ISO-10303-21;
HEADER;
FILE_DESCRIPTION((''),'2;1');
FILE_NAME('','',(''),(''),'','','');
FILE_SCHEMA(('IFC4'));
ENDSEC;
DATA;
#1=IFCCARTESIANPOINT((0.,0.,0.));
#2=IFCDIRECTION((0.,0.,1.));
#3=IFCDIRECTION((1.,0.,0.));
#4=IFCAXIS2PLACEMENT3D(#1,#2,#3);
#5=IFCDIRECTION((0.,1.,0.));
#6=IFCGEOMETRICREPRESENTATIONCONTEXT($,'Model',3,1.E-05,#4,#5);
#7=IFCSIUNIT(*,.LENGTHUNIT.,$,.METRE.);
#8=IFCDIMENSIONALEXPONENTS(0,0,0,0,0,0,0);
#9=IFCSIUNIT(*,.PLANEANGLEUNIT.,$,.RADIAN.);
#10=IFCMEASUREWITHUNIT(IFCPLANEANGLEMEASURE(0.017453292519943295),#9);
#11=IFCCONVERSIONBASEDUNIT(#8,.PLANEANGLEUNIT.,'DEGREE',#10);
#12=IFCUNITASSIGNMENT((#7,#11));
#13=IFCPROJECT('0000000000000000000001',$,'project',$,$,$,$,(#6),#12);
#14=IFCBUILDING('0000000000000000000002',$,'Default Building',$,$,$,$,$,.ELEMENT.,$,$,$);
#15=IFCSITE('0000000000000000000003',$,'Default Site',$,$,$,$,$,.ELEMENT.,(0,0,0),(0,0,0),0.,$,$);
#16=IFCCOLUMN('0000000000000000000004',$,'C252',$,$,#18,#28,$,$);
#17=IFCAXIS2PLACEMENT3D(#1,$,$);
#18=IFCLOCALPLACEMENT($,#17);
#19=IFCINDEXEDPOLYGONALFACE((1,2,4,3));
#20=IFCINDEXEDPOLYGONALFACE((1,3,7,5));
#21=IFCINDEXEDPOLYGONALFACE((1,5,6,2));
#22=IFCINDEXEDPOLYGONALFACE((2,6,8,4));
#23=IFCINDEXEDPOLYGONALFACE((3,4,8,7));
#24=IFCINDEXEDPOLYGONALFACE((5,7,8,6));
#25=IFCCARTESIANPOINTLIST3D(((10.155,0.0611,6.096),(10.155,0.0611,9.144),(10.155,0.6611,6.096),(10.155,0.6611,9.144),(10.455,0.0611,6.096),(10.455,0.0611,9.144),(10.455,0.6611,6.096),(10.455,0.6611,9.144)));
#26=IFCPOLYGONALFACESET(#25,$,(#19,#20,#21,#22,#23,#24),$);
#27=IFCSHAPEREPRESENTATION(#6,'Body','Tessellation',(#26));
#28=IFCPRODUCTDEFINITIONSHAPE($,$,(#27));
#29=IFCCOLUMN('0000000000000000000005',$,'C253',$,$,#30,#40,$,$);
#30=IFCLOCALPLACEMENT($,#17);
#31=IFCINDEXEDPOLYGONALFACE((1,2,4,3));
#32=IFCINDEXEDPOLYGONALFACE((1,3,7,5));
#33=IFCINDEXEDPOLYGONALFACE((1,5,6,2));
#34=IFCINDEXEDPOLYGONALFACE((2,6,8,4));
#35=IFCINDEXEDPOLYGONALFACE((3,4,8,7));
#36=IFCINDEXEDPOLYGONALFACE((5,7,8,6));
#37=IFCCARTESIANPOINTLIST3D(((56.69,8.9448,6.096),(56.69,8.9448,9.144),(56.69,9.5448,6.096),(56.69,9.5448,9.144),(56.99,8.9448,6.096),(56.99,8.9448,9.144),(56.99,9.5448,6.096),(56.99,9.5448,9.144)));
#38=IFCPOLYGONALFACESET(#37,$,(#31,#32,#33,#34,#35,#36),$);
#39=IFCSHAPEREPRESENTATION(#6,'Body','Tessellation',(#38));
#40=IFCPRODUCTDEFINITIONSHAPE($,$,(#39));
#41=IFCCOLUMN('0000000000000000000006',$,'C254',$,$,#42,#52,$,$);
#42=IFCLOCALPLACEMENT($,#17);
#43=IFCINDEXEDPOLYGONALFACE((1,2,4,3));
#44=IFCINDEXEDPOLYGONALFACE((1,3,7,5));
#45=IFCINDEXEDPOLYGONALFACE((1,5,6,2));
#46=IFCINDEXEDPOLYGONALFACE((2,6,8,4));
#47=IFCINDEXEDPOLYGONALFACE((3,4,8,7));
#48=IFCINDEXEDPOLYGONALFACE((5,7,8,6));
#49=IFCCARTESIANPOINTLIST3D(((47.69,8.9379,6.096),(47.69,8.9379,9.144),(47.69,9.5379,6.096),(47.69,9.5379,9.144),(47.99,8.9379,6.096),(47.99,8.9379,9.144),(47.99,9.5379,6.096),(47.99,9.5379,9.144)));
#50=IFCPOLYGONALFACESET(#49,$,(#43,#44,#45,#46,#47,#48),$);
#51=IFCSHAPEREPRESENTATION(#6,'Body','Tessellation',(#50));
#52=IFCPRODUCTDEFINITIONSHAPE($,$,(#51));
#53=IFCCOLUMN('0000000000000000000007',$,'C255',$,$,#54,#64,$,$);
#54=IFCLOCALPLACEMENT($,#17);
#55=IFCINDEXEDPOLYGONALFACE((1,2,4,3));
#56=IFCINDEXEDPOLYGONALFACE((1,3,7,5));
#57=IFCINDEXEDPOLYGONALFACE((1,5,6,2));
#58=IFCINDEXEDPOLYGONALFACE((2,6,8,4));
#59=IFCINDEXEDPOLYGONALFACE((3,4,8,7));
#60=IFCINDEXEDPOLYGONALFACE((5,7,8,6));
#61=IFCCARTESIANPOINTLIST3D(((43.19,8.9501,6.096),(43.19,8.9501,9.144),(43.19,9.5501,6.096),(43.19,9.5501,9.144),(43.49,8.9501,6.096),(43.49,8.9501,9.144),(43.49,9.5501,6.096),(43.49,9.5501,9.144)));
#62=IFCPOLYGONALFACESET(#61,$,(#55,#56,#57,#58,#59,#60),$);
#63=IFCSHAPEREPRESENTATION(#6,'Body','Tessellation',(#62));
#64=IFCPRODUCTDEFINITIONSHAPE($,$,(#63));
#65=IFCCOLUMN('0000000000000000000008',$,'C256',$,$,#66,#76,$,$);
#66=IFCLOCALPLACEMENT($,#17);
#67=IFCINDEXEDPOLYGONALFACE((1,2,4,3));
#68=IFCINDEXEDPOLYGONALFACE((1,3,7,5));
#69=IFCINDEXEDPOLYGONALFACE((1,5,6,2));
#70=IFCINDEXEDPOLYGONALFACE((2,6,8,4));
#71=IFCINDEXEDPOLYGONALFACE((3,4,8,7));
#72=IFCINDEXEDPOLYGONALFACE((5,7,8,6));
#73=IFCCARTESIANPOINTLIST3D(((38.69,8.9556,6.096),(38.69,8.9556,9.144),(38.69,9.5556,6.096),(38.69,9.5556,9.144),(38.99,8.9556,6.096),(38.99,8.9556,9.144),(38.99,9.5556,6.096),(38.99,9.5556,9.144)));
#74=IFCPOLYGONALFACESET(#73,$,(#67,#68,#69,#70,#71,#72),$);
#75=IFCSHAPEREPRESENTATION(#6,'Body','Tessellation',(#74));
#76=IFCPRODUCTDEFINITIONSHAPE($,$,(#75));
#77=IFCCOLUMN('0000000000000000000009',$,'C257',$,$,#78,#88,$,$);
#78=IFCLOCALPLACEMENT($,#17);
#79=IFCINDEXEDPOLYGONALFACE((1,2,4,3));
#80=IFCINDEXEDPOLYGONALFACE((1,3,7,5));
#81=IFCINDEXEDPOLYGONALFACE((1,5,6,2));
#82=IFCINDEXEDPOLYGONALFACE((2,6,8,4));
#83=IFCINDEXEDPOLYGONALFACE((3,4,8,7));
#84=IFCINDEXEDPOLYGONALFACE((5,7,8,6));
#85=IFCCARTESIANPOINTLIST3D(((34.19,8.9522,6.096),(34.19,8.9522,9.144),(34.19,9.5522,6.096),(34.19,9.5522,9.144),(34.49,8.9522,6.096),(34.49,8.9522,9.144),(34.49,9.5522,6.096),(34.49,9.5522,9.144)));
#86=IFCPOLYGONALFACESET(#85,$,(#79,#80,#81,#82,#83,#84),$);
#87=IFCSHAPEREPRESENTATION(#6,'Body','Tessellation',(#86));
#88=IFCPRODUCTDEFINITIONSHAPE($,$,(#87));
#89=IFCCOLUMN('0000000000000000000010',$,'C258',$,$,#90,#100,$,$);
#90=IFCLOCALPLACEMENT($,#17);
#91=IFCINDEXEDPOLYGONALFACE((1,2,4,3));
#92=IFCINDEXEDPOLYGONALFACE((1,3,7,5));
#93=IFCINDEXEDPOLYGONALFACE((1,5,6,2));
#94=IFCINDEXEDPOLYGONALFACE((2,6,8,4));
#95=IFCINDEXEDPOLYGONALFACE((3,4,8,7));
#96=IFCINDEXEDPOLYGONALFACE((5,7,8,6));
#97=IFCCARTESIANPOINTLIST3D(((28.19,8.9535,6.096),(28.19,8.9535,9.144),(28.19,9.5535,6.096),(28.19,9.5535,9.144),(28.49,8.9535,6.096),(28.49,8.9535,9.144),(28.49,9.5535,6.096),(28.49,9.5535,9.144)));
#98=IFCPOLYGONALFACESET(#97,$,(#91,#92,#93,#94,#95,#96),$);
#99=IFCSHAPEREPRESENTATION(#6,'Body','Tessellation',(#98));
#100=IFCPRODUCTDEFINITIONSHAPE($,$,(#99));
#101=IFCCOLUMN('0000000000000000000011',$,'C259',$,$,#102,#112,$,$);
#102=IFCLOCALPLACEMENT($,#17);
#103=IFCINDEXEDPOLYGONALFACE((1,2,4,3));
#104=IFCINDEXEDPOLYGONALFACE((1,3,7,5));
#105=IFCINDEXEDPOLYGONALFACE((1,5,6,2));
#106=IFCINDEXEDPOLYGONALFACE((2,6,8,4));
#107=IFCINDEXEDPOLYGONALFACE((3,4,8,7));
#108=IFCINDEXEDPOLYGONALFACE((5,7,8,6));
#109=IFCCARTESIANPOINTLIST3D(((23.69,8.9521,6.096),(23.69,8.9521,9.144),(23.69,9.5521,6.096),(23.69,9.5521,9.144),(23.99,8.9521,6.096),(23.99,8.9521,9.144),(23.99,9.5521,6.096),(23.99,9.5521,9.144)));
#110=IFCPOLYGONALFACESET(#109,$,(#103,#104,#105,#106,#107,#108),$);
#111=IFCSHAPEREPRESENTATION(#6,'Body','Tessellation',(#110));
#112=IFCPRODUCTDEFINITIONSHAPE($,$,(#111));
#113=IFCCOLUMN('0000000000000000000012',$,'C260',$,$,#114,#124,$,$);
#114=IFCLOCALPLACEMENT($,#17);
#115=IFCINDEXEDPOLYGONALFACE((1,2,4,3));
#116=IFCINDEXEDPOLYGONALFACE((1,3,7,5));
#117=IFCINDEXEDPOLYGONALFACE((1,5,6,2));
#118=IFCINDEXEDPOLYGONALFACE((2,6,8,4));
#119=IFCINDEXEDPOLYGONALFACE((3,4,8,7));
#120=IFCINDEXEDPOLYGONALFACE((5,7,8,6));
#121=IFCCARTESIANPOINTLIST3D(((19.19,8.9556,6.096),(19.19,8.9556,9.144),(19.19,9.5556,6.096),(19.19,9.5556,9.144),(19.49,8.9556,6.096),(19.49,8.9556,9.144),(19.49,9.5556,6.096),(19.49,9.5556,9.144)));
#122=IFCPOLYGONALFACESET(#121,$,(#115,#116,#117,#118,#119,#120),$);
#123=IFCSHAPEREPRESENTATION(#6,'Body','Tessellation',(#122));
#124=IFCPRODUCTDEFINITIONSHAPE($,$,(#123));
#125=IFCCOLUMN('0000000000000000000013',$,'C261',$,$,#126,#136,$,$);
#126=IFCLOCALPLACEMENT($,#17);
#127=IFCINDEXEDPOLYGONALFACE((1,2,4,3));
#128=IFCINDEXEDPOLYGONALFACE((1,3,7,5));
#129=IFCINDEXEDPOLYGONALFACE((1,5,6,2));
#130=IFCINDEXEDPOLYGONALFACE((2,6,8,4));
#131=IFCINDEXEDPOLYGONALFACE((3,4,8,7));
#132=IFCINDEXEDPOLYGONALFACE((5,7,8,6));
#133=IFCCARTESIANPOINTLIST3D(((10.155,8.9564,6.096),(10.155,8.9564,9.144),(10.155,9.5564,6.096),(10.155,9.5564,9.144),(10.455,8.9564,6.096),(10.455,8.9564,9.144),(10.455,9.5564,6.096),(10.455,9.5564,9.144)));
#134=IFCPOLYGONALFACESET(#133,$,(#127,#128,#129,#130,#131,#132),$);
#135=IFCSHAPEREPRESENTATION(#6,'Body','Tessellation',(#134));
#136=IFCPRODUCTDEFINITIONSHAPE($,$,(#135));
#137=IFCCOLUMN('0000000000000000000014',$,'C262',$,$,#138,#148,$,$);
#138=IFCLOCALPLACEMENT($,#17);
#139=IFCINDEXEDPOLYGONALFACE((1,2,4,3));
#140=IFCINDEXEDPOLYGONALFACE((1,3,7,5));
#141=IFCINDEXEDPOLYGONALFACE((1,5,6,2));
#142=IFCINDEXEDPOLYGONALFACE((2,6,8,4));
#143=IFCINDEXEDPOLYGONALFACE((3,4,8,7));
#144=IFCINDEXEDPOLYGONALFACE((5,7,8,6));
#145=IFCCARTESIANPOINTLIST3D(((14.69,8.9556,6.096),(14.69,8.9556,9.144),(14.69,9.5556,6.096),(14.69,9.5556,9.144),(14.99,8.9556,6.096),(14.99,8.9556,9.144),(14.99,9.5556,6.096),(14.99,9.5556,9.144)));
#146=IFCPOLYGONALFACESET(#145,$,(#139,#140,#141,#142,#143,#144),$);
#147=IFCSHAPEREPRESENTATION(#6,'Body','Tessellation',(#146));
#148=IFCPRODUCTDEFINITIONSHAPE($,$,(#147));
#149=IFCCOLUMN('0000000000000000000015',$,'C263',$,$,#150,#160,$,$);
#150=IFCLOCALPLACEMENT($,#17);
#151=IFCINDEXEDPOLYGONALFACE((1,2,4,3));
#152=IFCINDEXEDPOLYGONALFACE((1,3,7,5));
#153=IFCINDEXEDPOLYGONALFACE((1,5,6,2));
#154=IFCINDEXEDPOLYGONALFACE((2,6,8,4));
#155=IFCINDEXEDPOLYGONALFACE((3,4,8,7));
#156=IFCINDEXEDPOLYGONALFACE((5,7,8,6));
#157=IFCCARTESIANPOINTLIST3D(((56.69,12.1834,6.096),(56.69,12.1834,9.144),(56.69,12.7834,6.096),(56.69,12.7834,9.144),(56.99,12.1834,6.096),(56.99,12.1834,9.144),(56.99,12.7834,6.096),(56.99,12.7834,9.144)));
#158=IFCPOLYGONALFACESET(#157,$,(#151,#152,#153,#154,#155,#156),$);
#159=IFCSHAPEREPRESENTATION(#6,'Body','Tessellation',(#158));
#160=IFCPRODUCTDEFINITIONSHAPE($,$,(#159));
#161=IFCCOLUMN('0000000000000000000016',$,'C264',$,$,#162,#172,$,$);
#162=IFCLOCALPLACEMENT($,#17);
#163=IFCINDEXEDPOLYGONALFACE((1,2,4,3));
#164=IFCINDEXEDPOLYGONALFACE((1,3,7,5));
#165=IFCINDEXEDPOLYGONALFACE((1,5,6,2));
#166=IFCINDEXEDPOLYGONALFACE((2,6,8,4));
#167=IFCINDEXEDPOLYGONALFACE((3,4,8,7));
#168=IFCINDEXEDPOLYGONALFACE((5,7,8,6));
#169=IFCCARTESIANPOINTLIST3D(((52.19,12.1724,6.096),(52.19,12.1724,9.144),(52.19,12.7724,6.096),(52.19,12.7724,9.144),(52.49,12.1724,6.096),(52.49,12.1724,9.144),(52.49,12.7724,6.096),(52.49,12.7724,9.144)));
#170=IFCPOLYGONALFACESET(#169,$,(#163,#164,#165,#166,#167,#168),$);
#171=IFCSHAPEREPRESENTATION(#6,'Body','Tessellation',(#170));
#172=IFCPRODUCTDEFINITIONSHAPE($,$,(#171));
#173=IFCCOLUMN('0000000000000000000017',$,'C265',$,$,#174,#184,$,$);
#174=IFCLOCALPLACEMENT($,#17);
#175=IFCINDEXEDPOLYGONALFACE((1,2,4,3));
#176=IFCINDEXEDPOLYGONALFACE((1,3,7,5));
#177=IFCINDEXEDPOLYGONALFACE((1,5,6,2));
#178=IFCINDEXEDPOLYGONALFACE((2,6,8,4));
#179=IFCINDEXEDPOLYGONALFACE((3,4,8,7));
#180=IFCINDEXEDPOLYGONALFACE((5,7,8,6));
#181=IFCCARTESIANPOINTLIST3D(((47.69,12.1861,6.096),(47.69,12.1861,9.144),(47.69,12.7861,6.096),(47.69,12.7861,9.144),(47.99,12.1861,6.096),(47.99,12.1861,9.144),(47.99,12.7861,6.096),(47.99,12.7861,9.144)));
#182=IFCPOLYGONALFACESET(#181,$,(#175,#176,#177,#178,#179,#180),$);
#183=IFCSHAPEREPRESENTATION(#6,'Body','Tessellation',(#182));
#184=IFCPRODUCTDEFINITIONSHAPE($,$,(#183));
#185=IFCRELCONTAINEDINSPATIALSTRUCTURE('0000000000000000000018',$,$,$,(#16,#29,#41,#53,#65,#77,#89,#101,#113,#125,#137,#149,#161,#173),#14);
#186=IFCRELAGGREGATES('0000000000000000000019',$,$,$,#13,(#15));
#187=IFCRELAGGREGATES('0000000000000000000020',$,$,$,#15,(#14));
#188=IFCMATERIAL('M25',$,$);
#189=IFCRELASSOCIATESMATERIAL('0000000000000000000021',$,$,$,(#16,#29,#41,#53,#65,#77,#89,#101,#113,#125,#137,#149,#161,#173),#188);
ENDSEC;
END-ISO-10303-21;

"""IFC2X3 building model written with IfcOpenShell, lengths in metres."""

from ifc_helpers import new_model, entity, si_unit, converted_unit, direction, frame, frame_2d, origin_with_axes, place, context, project, spatial, rectangle, extrude, material, element, save


model = new_model("IFC2X3")

# Units and contexts
model_context = context("Model", 3, precision=1e-05, world=origin_with_axes(), true_north=direction((0.0, 1.0, 0.0)))
ifc_project = project(units=[si_unit("LENGTHUNIT", "METRE"), converted_unit("PLANEANGLEUNIT", "DEGREE", entity("IfcPlaneAngleMeasure", 0.017453292519943295), si_unit("PLANEANGLEUNIT", "RADIAN"), dimensions=[0, 0, 0, 0, 0, 0, 0])], contexts=[model_context])

# Site, building
site = spatial("IfcSite", under=ifc_project, Name="Default Site", CompositionType="ELEMENT", RefLatitude=(0, 0, 0), RefLongitude=(0, 0, 0), RefElevation=0.0)
building = spatial("IfcBuilding", under=site, Name="Default Building", CompositionType="ELEMENT")

# Columns
ifc_material = material(Name="M25")
placement = place(None, origin_with_axes())
element("IfcColumn", 1, at=placement, inside=building, material=ifc_material, Name="C252", context=model_context, shape_type="SweptSolid", body=[
    extrude(rectangle(XDim=0.3, YDim=0.6, at=frame_2d((0.0, 0.0), x_axis=(1.0, 0.0, 0.0))), frame((10.305, 0.3611, 6.096), z_axis=(0.0, 0.0, 1.0), x_axis=(1.0, 0.0, 0.0)), (0.0, 0.0, 1.0), 3.048),
])
element("IfcColumn", 2, at=placement, inside=building, material=ifc_material, Name="C253", context=model_context, shape_type="SweptSolid", body=[
    extrude(rectangle(XDim=0.3, YDim=0.6, at=frame_2d((0.0, 0.0), x_axis=(1.0, 0.0, 0.0))), frame((56.84, 9.2448, 6.096), z_axis=(0.0, 0.0, 1.0), x_axis=(1.0, 0.0, 0.0)), (0.0, 0.0, 1.0), 3.048),
])
element("IfcColumn", 3, at=placement, inside=building, material=ifc_material, Name="C254", context=model_context, shape_type="SweptSolid", body=[
    extrude(rectangle(XDim=0.3, YDim=0.6, at=frame_2d((0.0, 0.0), x_axis=(1.0, 0.0, 0.0))), frame((47.84, 9.2379, 6.096), z_axis=(0.0, 0.0, 1.0), x_axis=(1.0, 0.0, 0.0)), (0.0, 0.0, 1.0), 3.048),
])
element("IfcColumn", 4, at=placement, inside=building, material=ifc_material, Name="C255", context=model_context, shape_type="SweptSolid", body=[
    extrude(rectangle(XDim=0.3, YDim=0.6, at=frame_2d((0.0, 0.0), x_axis=(1.0, 0.0, 0.0))), frame((43.34, 9.2501, 6.096), z_axis=(0.0, 0.0, 1.0), x_axis=(1.0, 0.0, 0.0)), (0.0, 0.0, 1.0), 3.048),
])
element("IfcColumn", 5, at=placement, inside=building, material=ifc_material, Name="C256", context=model_context, shape_type="SweptSolid", body=[
    extrude(rectangle(XDim=0.3, YDim=0.6, at=frame_2d((0.0, 0.0), x_axis=(1.0, 0.0, 0.0))), frame((38.84, 9.2556, 6.096), z_axis=(0.0, 0.0, 1.0), x_axis=(1.0, 0.0, 0.0)), (0.0, 0.0, 1.0), 3.048),
])
element("IfcColumn", 6, at=placement, inside=building, material=ifc_material, Name="C257", context=model_context, shape_type="SweptSolid", body=[
    extrude(rectangle(XDim=0.3, YDim=0.6, at=frame_2d((0.0, 0.0), x_axis=(1.0, 0.0, 0.0))), frame((34.34, 9.2522, 6.096), z_axis=(0.0, 0.0, 1.0), x_axis=(1.0, 0.0, 0.0)), (0.0, 0.0, 1.0), 3.048),
])
element("IfcColumn", 7, at=placement, inside=building, material=ifc_material, Name="C258", context=model_context, shape_type="SweptSolid", body=[
    extrude(rectangle(XDim=0.3, YDim=0.6, at=frame_2d((0.0, 0.0), x_axis=(1.0, 0.0, 0.0))), frame((28.34, 9.2535, 6.096), z_axis=(0.0, 0.0, 1.0), x_axis=(1.0, 0.0, 0.0)), (0.0, 0.0, 1.0), 3.048),
])
element("IfcColumn", 8, at=placement, inside=building, material=ifc_material, Name="C259", context=model_context, shape_type="SweptSolid", body=[
    extrude(rectangle(XDim=0.3, YDim=0.6, at=frame_2d((0.0, 0.0), x_axis=(1.0, 0.0, 0.0))), frame((23.84, 9.2521, 6.096), z_axis=(0.0, 0.0, 1.0), x_axis=(1.0, 0.0, 0.0)), (0.0, 0.0, 1.0), 3.048),
])
element("IfcColumn", 9, at=placement, inside=building, material=ifc_material, Name="C260", context=model_context, shape_type="SweptSolid", body=[
    extrude(rectangle(XDim=0.3, YDim=0.6, at=frame_2d((0.0, 0.0), x_axis=(1.0, 0.0, 0.0))), frame((19.34, 9.2556, 6.096), z_axis=(0.0, 0.0, 1.0), x_axis=(1.0, 0.0, 0.0)), (0.0, 0.0, 1.0), 3.048),
])
element("IfcColumn", 10, at=placement, inside=building, material=ifc_material, Name="C261", context=model_context, shape_type="SweptSolid", body=[
    extrude(rectangle(XDim=0.3, YDim=0.6, at=frame_2d((0.0, 0.0), x_axis=(1.0, 0.0, 0.0))), frame((10.305, 9.2564, 6.096), z_axis=(0.0, 0.0, 1.0), x_axis=(1.0, 0.0, 0.0)), (0.0, 0.0, 1.0), 3.048),
])
element("IfcColumn", 11, at=placement, inside=building, material=ifc_material, Name="C262", context=model_context, shape_type="SweptSolid", body=[
    extrude(rectangle(XDim=0.3, YDim=0.6, at=frame_2d((0.0, 0.0), x_axis=(1.0, 0.0, 0.0))), frame((14.84, 9.2556, 6.096), z_axis=(0.0, 0.0, 1.0), x_axis=(1.0, 0.0, 0.0)), (0.0, 0.0, 1.0), 3.048),
])
element("IfcColumn", 12, at=placement, inside=building, material=ifc_material, Name="C263", context=model_context, shape_type="SweptSolid", body=[
    extrude(rectangle(XDim=0.3, YDim=0.6, at=frame_2d((0.0, 0.0), x_axis=(1.0, 0.0, 0.0))), frame((56.84, 12.4834, 6.096), z_axis=(0.0, 0.0, 1.0), x_axis=(1.0, 0.0, 0.0)), (0.0, 0.0, 1.0), 3.048),
])
element("IfcColumn", 13, at=placement, inside=building, material=ifc_material, Name="C264", context=model_context, shape_type="SweptSolid", body=[
    extrude(rectangle(XDim=0.3, YDim=0.6, at=frame_2d((0.0, 0.0), x_axis=(1.0, 0.0, 0.0))), frame((52.34, 12.4724, 6.096), z_axis=(0.0, 0.0, 1.0), x_axis=(1.0, 0.0, 0.0)), (0.0, 0.0, 1.0), 3.048),
])
element("IfcColumn", 14, at=placement, inside=building, material=ifc_material, Name="C265", context=model_context, shape_type="SweptSolid", body=[
    extrude(rectangle(XDim=0.3, YDim=0.6, at=frame_2d((0.0, 0.0), x_axis=(1.0, 0.0, 0.0))), frame((47.84, 12.4861, 6.096), z_axis=(0.0, 0.0, 1.0), x_axis=(1.0, 0.0, 0.0)), (0.0, 0.0, 1.0), 3.048),
])

save(model, "model.ifc")
